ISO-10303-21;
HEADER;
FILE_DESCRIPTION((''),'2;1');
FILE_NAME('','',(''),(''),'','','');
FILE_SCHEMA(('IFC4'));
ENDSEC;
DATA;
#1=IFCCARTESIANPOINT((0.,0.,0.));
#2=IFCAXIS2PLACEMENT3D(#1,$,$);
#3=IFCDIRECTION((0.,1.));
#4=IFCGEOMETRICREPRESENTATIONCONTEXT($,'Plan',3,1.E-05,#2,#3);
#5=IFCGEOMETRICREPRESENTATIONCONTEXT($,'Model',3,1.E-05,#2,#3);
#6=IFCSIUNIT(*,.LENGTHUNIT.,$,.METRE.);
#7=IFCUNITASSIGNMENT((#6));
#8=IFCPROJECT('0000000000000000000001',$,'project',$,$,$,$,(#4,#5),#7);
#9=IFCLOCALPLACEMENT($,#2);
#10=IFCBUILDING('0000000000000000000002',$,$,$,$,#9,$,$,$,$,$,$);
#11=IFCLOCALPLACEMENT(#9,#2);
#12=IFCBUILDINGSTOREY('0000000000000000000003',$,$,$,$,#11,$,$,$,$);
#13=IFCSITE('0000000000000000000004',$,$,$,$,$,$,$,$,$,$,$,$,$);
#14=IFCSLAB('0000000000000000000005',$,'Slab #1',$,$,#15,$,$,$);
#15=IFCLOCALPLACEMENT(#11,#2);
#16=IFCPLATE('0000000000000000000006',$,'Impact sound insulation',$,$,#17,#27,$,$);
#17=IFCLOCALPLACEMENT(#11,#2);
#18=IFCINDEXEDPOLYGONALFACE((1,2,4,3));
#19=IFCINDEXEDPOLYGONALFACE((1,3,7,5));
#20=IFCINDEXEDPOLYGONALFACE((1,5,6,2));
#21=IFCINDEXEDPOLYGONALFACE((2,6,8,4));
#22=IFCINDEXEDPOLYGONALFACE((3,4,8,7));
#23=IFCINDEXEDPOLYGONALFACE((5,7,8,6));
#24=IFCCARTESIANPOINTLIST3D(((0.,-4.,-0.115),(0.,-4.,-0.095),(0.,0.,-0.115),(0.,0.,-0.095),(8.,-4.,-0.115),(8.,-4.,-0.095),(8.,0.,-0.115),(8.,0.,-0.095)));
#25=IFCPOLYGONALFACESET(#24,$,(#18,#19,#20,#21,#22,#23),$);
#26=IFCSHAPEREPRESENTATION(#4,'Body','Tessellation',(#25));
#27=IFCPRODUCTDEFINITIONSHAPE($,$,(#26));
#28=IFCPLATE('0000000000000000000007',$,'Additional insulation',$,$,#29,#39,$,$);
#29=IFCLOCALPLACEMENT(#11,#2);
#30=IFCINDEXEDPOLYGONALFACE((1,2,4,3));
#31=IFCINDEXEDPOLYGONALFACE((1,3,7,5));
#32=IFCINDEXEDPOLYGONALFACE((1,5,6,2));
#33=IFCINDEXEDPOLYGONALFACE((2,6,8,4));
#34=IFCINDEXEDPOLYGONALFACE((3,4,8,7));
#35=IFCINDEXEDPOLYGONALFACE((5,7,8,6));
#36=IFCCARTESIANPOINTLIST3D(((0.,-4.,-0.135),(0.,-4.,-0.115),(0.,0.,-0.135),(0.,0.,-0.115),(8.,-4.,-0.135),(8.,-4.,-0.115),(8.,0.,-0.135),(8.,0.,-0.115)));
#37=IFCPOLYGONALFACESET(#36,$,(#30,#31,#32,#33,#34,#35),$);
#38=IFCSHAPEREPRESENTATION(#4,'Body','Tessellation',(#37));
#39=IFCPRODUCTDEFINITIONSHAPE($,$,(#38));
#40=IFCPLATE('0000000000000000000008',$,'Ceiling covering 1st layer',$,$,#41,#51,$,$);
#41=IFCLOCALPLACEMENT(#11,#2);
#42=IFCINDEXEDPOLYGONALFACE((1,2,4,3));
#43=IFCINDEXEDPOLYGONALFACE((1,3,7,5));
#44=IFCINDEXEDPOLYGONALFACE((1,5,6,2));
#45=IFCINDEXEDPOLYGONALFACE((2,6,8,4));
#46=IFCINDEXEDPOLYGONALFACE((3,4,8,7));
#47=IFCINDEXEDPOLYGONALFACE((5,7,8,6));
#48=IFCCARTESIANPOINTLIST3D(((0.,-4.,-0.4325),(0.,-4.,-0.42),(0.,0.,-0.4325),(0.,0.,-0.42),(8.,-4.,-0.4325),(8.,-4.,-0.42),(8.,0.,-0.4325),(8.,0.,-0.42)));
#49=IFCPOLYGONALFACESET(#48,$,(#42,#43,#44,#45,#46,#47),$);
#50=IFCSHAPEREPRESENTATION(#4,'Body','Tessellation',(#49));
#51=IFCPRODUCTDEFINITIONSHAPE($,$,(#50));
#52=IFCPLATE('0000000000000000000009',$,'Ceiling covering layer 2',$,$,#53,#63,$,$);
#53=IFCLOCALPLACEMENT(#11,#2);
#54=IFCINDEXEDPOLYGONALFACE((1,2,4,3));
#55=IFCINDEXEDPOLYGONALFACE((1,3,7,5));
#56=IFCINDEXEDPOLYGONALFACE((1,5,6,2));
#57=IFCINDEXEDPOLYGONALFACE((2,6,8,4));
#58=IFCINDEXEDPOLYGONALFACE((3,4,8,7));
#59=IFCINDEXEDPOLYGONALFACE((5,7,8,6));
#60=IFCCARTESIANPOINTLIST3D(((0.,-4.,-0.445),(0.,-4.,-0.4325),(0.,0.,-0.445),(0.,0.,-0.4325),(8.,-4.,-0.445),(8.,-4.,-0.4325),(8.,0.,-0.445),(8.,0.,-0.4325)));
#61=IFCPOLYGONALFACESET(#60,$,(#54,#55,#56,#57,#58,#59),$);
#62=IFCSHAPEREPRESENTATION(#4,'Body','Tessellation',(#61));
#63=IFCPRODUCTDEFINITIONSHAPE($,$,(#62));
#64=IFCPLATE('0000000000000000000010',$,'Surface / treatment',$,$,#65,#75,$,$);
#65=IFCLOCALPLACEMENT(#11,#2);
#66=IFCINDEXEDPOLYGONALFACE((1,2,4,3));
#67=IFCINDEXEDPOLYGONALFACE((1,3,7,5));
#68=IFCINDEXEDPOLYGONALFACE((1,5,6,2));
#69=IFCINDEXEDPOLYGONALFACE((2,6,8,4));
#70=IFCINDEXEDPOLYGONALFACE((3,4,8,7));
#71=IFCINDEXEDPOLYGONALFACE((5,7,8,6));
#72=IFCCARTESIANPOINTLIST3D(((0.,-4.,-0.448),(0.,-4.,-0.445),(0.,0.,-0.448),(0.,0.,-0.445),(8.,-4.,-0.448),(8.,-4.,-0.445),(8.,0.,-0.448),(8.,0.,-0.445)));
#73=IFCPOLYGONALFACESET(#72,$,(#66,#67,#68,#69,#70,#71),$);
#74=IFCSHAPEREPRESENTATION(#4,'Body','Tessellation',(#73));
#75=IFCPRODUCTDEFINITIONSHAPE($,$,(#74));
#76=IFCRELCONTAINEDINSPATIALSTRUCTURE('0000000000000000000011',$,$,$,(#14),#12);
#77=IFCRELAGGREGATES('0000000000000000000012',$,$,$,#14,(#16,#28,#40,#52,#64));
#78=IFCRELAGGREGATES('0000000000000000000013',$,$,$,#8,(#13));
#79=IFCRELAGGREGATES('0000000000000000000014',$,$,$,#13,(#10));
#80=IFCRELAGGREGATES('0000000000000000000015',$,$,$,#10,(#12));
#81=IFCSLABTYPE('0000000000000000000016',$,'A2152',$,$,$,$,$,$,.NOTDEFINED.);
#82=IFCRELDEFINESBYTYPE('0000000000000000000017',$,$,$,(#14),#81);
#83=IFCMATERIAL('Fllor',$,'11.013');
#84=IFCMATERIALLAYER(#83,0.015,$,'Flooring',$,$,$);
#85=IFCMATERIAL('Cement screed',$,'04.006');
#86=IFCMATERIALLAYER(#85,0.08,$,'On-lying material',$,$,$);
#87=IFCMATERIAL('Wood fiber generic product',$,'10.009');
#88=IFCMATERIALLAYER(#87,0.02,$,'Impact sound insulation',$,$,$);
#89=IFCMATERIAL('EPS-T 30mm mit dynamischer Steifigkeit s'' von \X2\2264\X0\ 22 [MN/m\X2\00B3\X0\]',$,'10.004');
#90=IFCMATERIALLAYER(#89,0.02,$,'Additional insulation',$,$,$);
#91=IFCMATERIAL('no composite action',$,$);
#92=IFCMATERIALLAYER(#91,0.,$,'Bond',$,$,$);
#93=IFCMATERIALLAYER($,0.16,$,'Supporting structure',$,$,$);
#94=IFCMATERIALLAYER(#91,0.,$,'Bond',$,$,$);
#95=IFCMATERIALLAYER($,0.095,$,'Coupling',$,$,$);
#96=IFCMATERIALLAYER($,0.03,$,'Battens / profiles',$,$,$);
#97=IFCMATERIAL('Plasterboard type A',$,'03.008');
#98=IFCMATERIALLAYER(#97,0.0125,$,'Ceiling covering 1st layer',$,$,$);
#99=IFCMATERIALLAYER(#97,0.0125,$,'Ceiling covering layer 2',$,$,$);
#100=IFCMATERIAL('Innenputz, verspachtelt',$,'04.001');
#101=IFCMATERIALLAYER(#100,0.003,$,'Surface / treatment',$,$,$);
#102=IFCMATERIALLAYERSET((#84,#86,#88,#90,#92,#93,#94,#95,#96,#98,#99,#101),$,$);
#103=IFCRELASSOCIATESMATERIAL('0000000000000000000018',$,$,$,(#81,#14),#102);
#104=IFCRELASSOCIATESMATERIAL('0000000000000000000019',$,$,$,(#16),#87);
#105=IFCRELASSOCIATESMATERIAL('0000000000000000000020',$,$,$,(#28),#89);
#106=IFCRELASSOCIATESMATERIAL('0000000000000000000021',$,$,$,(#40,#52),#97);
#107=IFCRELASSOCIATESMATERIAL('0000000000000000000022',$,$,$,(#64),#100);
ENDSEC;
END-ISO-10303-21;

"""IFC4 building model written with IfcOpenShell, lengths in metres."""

from ifc_helpers import new_model, si_unit, direction, frame, frame_2d, origin, place, context, project, spatial, rectangle, extrude, material, layer, layer_set, type_object, element, aggregate, save


model = new_model("IFC4")

# Units and contexts
plan_context = context("Plan", 3, precision=1e-05, world=origin(), true_north=direction((0.0, 1.0)))
model_context = context("Model", 3, precision=1e-05, world=origin(), true_north=direction((0.0, 1.0)))
ifc_project = project(units=[si_unit("LENGTHUNIT", "METRE")], contexts=[plan_context, model_context])

# Site, building, storey
site = spatial("IfcSite", under=ifc_project)
building_placement = place(None, origin())
building = spatial("IfcBuilding", under=site, at=building_placement)
storey_placement = place(building_placement, origin())
storey = spatial("IfcBuildingStorey", under=building, at=storey_placement)

# Slab, plates
ifc_material_1 = material(Name="Fllor", Category="11.013")
ifc_layer_1 = layer(ifc_material_1, 0.015, Name="Flooring")
ifc_material_2 = material(Name="Cement screed", Category="04.006")
ifc_layer_2 = layer(ifc_material_2, 0.08, Name="On-lying material")
ifc_material_3 = material(Name="Wood fiber generic product", Category="10.009")
ifc_layer_3 = layer(ifc_material_3, 0.02, Name="Impact sound insulation")
ifc_material_4 = material(Name="EPS-T 30mm mit dynamischer Steifigkeit s' von ≤ 22 [MN/m³]", Category="10.004")
ifc_layer_4 = layer(ifc_material_4, 0.02, Name="Additional insulation")
ifc_material_5 = material(Name="no composite action")
ifc_layer_5 = layer(ifc_material_5, 0.0, Name="Bond")
ifc_layer_6 = layer(None, 0.16, Name="Supporting structure")
ifc_layer_7 = layer(ifc_material_5, 0.0, Name="Bond")
ifc_layer_8 = layer(None, 0.095, Name="Coupling")
ifc_layer_9 = layer(None, 0.03, Name="Battens / profiles")
ifc_material_6 = material(Name="Plasterboard type A", Category="03.008")
ifc_layer_10 = layer(ifc_material_6, 0.0125, Name="Ceiling covering 1st layer")
ifc_layer_11 = layer(ifc_material_6, 0.0125, Name="Ceiling covering layer 2")
ifc_material_7 = material(Name="Innenputz, verspachtelt", Category="04.001")
ifc_layer_12 = layer(ifc_material_7, 0.003, Name="Surface / treatment")
ifc_layer_set = layer_set([ifc_layer_1, ifc_layer_2, ifc_layer_3, ifc_layer_4, ifc_layer_5, ifc_layer_6, ifc_layer_7, ifc_layer_8, ifc_layer_9, ifc_layer_10, ifc_layer_11, ifc_layer_12])
slab_type = type_object("IfcSlabType", Name="A2152", PredefinedType="NOTDEFINED", material=ifc_layer_set)
slab_placement = place(None, frame((0.0, 0.0, 0.0), z_axis=(0.0, 0.0, -1.0), x_axis=(1.0, 0.0, 0.0)))
slab = element("IfcSlab", 1, at=slab_placement, inside=storey, type_object=slab_type, material=ifc_layer_set, Name="Slab #1")
plate_1_placement = place(slab_placement, origin())
plate_1 = element("IfcPlate", 2, at=plate_1_placement, material=ifc_material_3, Name="Impact sound insulation", context=plan_context, shape_type="SweptSolid", body=[
    extrude(rectangle(XDim=8.0, YDim=4.0, at=frame_2d((4.0, 2.0), x_axis=(1.0, 0.0))), frame((0.0, 0.0, 0.095), z_axis=(0.0, 0.0, 1.0), x_axis=(1.0, 0.0, 0.0)), (0.0, 0.0, 1.0), 0.02),
])
plate_2_placement = place(slab_placement, origin())
plate_2 = element("IfcPlate", 3, at=plate_2_placement, material=ifc_material_4, Name="Additional insulation", context=plan_context, shape_type="SweptSolid", body=[
    extrude(rectangle(XDim=8.0, YDim=4.0, at=frame_2d((4.0, 2.0), x_axis=(1.0, 0.0))), frame((0.0, 0.0, 0.115), z_axis=(0.0, 0.0, 1.0), x_axis=(1.0, 0.0, 0.0)), (0.0, 0.0, 1.0), 0.02),
])
plate_3_placement = place(slab_placement, origin())
plate_3 = element("IfcPlate", 4, at=plate_3_placement, material=ifc_material_6, Name="Ceiling covering 1st layer", context=plan_context, shape_type="SweptSolid", body=[
    extrude(rectangle(XDim=8.0, YDim=4.0, at=frame_2d((4.0, 2.0), x_axis=(1.0, 0.0))), frame((0.0, 0.0, 0.42), z_axis=(0.0, 0.0, 1.0), x_axis=(1.0, 0.0, 0.0)), (0.0, 0.0, 1.0), 0.0125),
])
plate_4_placement = place(slab_placement, origin())
plate_4 = element("IfcPlate", 5, at=plate_4_placement, material=ifc_material_6, Name="Ceiling covering layer 2", context=plan_context, shape_type="SweptSolid", body=[
    extrude(rectangle(XDim=8.0, YDim=4.0, at=frame_2d((4.0, 2.0), x_axis=(1.0, 0.0))), frame((0.0, 0.0, 0.4325), z_axis=(0.0, 0.0, 1.0), x_axis=(1.0, 0.0, 0.0)), (0.0, 0.0, 1.0), 0.0125),
])
plate_5_placement = place(slab_placement, origin())
plate_5 = element("IfcPlate", 6, at=plate_5_placement, material=ifc_material_7, Name="Surface / treatment", context=plan_context, shape_type="SweptSolid", body=[
    extrude(rectangle(XDim=8.0, YDim=4.0, at=frame_2d((4.0, 2.0), x_axis=(1.0, 0.0))), frame((0.0, 0.0, 0.445), z_axis=(0.0, 0.0, 1.0), x_axis=(1.0, 0.0, 0.0)), (0.0, 0.0, 1.0), 0.003),
])
aggregate(slab, [plate_1, plate_2, plate_3, plate_4, plate_5])

save(model, "model.ifc")
